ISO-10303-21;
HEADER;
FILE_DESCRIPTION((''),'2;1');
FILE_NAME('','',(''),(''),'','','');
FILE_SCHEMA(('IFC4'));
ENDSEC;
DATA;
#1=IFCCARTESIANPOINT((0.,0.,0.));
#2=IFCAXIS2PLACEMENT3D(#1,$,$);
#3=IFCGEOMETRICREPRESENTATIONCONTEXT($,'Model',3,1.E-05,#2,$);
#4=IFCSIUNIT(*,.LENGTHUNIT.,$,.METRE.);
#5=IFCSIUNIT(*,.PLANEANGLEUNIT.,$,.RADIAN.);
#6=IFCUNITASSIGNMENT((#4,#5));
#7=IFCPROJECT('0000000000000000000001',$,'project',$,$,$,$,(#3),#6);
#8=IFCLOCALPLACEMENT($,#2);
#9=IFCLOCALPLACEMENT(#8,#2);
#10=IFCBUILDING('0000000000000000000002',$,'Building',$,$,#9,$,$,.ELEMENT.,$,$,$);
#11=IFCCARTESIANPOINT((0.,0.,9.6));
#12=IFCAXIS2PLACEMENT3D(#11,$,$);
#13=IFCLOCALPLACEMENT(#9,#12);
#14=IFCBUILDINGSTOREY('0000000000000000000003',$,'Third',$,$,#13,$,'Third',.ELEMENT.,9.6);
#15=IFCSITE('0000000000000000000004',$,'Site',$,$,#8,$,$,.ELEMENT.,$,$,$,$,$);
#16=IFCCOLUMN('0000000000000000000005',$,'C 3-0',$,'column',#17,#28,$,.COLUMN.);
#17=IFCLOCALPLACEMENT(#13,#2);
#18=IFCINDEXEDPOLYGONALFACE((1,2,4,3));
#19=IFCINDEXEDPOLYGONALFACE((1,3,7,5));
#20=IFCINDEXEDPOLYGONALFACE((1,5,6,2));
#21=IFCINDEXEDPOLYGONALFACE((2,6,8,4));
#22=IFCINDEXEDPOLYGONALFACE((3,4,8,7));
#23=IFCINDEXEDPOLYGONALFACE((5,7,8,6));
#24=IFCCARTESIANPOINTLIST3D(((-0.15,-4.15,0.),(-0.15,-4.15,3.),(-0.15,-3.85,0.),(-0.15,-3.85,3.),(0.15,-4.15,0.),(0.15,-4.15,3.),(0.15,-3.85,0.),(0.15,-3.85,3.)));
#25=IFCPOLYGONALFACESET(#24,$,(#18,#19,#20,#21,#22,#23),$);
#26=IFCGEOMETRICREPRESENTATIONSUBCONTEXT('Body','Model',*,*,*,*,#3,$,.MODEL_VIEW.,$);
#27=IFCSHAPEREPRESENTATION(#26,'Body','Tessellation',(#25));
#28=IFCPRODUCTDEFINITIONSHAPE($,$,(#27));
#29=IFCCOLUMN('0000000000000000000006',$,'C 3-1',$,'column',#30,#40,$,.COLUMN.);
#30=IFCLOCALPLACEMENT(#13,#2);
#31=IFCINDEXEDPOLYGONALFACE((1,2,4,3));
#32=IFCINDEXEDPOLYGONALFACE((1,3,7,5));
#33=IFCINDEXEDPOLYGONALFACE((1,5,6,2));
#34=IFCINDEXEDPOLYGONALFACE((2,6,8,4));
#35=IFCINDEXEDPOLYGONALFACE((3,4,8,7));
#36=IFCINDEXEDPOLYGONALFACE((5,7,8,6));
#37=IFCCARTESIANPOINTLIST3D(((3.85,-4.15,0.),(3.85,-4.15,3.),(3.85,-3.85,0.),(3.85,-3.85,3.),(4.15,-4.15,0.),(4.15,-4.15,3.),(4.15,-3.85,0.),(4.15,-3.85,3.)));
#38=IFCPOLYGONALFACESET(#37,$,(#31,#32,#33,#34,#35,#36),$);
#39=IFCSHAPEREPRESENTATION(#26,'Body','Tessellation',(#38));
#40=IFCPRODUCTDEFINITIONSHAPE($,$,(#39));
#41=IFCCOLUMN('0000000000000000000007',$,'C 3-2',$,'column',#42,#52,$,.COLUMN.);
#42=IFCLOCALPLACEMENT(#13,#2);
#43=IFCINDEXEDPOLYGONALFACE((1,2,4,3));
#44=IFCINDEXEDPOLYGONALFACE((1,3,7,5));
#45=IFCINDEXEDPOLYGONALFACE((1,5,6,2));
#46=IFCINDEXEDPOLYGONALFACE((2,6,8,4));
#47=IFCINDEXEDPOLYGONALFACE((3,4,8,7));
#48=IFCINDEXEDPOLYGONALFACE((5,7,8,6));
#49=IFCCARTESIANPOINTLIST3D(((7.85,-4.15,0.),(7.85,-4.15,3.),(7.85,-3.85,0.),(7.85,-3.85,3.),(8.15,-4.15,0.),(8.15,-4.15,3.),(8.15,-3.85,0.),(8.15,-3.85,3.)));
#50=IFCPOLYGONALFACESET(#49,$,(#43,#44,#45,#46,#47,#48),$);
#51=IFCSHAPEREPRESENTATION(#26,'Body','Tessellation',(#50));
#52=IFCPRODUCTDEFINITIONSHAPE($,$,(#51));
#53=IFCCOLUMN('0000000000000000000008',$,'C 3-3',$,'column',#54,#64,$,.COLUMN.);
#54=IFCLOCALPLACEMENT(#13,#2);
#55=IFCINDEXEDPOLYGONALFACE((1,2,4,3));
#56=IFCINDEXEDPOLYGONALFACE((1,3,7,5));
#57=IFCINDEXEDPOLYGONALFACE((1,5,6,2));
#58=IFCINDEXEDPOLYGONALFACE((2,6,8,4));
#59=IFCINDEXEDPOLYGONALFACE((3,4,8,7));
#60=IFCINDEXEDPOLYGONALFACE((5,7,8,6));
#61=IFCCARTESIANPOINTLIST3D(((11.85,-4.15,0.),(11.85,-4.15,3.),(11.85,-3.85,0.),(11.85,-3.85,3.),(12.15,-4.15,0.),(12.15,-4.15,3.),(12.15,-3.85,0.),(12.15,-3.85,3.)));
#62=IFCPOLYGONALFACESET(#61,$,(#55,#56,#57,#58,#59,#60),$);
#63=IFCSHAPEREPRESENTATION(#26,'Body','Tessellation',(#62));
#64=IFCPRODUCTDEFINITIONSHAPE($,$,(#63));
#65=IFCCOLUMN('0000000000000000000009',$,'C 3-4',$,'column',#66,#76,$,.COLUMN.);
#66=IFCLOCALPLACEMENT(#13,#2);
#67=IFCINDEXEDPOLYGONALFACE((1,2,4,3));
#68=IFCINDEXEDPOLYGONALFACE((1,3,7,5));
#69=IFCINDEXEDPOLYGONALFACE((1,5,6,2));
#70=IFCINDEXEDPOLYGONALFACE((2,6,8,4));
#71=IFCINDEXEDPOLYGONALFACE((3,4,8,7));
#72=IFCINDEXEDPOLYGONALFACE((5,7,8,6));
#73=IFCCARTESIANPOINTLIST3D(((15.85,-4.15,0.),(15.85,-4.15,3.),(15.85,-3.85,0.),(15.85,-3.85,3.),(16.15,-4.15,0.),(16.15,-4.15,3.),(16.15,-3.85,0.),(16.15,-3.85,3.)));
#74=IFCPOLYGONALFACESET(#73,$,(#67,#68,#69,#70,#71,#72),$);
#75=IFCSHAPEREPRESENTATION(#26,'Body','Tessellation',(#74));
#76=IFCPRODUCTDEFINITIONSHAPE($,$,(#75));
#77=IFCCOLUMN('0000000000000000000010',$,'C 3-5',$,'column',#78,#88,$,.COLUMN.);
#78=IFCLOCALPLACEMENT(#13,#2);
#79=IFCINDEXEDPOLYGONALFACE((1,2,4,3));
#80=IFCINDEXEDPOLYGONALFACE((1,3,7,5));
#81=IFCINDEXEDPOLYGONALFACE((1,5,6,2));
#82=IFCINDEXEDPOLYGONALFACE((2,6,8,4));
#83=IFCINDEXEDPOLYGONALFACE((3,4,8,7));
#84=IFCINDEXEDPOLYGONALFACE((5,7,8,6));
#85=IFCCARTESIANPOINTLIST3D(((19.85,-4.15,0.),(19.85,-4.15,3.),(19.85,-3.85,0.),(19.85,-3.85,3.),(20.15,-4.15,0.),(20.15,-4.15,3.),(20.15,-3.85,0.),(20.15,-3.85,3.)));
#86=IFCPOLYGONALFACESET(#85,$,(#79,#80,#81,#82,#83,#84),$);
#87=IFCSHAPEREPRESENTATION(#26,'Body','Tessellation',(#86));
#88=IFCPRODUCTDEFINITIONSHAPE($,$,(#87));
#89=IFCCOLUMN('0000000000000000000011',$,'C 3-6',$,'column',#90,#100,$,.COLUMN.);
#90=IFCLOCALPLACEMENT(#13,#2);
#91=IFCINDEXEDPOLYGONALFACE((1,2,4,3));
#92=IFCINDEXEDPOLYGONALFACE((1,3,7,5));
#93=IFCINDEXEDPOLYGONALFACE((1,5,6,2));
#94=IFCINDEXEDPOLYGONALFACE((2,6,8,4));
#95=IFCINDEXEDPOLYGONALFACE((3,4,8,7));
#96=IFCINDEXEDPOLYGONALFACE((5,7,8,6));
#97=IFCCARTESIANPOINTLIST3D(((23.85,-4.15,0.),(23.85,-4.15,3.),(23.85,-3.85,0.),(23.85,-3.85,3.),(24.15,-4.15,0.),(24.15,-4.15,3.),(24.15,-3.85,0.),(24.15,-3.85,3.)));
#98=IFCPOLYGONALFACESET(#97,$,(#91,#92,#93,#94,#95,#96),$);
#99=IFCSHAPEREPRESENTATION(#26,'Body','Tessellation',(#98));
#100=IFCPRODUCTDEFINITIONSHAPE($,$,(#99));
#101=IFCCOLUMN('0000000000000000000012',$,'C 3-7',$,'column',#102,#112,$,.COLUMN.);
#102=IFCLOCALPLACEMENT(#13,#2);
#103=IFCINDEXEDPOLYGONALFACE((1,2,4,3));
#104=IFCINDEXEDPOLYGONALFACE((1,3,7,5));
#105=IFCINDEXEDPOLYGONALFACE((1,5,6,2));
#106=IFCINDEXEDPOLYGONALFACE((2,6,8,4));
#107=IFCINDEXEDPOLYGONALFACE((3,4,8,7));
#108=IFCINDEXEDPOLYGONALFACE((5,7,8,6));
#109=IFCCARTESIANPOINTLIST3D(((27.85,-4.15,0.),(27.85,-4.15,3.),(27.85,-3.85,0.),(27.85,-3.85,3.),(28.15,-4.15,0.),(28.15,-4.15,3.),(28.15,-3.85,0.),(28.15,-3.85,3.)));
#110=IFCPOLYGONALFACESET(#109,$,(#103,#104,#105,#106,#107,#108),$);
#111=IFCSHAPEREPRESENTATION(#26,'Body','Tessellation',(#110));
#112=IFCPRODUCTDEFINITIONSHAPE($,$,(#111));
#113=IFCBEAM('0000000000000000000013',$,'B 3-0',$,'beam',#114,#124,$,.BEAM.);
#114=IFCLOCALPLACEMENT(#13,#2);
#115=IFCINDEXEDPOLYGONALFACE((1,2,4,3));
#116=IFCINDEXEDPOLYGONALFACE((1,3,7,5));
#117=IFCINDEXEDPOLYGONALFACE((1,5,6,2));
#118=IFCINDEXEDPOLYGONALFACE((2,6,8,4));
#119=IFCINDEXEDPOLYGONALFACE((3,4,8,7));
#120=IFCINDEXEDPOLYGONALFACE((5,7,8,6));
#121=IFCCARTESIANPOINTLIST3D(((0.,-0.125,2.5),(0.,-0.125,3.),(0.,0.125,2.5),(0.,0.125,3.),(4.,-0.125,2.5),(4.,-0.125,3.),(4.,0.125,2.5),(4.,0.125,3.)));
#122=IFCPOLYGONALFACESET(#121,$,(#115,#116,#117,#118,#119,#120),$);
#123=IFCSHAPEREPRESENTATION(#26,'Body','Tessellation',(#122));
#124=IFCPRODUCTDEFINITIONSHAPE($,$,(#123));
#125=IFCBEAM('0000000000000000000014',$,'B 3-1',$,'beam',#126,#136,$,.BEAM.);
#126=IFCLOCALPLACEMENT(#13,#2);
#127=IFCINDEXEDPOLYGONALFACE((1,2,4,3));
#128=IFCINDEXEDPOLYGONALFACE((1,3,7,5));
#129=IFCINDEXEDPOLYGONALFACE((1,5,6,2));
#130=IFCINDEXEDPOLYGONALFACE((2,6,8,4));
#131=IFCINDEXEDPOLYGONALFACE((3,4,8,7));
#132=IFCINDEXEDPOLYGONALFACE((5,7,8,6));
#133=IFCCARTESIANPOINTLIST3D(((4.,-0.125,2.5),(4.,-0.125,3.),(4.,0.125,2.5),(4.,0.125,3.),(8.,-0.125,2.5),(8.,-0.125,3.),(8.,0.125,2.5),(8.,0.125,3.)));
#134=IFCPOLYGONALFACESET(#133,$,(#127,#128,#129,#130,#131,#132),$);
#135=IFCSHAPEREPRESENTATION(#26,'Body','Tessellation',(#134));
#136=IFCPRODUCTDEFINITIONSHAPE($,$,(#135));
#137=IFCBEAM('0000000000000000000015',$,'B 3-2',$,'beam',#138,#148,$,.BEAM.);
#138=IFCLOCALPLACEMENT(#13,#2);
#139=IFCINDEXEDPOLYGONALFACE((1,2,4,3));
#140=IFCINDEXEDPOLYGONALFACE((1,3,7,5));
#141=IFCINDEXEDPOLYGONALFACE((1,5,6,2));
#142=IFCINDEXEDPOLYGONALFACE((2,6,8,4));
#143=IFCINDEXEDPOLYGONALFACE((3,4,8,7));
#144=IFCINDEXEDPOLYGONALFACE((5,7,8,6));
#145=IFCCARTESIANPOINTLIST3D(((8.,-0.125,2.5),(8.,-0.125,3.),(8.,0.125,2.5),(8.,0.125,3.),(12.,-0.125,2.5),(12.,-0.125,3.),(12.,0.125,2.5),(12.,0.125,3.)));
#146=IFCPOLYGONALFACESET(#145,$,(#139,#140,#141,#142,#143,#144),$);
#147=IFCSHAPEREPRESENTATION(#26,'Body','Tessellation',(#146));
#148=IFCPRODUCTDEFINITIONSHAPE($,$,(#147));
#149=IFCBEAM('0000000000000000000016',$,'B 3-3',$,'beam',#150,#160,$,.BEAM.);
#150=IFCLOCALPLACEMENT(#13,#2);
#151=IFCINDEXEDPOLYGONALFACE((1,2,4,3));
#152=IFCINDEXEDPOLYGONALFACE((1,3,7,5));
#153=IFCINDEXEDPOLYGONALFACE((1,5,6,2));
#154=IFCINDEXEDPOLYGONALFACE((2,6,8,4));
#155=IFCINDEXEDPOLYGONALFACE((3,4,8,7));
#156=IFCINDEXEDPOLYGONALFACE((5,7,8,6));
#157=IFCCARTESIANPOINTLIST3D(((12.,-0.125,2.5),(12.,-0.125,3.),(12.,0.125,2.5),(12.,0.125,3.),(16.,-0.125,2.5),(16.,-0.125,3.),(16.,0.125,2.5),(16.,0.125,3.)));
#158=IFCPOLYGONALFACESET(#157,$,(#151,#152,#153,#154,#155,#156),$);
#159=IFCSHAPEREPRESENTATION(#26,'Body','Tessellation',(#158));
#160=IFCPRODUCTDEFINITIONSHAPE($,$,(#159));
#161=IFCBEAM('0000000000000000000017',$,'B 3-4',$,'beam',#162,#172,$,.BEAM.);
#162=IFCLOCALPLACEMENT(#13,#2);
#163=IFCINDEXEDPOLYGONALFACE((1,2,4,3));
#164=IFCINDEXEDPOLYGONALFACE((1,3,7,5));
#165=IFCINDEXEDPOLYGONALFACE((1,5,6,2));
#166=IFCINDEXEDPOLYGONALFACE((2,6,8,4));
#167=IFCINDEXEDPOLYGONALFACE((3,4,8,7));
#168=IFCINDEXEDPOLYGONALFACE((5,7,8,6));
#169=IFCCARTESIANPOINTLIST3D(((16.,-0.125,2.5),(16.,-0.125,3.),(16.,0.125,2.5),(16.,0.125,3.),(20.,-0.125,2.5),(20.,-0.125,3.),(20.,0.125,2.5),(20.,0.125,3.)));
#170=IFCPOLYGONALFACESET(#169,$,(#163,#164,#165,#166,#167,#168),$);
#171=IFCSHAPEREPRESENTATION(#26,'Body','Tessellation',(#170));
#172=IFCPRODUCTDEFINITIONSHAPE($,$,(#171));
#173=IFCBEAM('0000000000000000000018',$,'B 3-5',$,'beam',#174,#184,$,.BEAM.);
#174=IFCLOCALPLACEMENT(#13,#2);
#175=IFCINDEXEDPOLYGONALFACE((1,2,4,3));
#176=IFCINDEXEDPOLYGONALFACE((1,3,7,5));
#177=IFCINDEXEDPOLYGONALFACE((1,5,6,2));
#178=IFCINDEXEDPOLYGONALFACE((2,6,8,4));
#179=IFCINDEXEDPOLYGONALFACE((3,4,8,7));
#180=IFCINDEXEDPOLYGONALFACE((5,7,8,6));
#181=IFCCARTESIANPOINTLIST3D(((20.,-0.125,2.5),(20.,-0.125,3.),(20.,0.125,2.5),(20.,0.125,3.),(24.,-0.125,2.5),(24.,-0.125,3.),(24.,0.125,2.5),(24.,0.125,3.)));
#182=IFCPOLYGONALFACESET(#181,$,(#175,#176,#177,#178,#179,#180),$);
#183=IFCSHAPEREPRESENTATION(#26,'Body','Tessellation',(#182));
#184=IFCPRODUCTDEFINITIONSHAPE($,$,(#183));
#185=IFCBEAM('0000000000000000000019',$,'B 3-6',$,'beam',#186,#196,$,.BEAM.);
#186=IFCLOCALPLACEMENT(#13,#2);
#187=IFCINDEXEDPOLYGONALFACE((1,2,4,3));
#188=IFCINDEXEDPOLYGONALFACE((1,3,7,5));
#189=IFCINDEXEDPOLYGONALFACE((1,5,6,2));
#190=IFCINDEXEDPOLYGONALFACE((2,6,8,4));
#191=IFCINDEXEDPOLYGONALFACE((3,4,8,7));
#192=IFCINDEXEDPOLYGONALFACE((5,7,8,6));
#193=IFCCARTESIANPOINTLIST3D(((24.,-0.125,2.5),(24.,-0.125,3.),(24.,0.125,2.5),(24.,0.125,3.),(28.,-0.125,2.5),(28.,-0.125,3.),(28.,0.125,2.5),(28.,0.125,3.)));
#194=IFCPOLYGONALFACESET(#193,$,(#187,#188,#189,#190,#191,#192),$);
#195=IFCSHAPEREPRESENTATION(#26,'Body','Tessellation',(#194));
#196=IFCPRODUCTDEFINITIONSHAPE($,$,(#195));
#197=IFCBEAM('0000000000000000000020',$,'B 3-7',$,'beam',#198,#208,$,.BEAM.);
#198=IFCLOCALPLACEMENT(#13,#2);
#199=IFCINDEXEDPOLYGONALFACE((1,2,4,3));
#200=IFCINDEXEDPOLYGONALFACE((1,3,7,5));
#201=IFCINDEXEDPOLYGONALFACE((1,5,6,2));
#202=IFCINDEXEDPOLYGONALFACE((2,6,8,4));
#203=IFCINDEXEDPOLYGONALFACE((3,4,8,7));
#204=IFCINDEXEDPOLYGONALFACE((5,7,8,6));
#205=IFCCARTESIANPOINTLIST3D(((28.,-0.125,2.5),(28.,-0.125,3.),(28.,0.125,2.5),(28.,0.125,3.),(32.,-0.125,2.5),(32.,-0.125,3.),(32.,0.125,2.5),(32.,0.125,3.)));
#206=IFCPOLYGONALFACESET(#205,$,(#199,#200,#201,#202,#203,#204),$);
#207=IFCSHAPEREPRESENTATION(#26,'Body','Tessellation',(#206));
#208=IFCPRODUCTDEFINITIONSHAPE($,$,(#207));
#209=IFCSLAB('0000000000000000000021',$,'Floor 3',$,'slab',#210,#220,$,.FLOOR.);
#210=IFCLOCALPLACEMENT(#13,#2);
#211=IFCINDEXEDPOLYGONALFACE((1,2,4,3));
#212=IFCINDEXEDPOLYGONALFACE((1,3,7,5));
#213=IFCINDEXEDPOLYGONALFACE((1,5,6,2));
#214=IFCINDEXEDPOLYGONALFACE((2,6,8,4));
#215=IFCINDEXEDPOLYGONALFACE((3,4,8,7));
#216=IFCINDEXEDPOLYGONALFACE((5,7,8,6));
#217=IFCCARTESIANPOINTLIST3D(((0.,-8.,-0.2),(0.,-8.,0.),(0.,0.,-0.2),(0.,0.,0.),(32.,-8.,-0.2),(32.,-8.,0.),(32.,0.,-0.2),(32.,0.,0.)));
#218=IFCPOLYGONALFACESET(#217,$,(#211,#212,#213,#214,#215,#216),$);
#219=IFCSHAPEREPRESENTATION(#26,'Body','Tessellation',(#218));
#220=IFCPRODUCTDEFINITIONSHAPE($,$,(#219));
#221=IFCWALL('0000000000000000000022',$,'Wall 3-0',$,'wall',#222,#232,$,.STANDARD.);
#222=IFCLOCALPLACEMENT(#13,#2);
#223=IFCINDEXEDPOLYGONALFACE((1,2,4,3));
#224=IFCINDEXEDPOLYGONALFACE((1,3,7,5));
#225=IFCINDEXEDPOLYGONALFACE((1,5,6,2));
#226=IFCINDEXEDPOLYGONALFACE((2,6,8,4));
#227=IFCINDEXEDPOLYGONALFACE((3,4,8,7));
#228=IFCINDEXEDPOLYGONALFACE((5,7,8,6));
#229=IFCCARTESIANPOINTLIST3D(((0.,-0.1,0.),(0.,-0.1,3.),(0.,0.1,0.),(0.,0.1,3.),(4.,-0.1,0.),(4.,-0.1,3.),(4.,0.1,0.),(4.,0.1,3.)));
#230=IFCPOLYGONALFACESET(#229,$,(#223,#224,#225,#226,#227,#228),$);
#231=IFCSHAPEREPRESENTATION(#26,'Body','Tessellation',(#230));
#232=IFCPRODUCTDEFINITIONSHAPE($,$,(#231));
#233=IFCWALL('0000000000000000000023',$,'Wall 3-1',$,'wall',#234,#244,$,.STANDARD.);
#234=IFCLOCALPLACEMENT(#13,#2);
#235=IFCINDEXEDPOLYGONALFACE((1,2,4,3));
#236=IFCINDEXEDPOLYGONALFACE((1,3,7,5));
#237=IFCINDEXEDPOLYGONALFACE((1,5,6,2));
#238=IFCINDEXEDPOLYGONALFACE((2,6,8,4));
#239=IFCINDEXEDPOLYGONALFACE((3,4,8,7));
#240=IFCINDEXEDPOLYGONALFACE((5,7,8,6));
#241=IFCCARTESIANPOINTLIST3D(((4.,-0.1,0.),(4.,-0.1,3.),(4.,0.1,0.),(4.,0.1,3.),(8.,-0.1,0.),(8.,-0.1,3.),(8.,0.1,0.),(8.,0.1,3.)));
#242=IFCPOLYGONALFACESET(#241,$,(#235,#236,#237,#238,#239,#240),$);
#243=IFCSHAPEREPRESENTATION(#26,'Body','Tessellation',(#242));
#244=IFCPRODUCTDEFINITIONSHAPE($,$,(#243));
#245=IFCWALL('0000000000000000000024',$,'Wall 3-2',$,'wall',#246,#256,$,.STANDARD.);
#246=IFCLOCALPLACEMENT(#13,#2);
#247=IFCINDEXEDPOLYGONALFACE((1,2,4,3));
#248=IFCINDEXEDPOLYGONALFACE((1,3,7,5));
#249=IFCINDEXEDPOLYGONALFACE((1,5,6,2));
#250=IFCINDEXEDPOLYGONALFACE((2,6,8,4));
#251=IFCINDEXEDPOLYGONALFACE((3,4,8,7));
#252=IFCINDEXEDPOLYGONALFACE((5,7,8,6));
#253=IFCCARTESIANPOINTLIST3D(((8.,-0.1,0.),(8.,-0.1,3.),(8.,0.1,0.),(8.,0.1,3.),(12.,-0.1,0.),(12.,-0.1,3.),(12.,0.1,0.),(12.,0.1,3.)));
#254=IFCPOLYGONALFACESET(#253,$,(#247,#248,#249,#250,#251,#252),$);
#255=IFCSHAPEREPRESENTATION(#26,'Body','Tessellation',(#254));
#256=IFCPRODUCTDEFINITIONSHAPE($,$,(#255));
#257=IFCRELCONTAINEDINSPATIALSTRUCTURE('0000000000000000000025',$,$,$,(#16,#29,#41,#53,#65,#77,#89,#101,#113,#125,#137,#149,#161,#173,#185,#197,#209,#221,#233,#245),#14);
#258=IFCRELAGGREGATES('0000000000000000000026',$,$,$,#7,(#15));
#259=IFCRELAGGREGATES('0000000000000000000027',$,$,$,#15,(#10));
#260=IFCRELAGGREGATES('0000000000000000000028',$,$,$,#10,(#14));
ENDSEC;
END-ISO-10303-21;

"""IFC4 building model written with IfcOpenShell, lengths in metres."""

from ifc_helpers import new_model, si_unit, frame, frame_2d, origin, origin_2d, place, context, subcontext, project, spatial, polyline, rectangle, outline, extrude, element, save


model = new_model("IFC4")

# Units and contexts
model_context = context("Model", 3, precision=1e-05, world=origin())
body_context = subcontext(model_context, "Body", "Model", "MODEL_VIEW")
ifc_project = project(units=[si_unit("LENGTHUNIT", "METRE"), si_unit("PLANEANGLEUNIT", "RADIAN")], contexts=[model_context])

# Site, building, storey
site_placement = place(None, origin())
site = spatial("IfcSite", under=ifc_project, at=site_placement, Name="Site", CompositionType="ELEMENT")
building_placement = place(site_placement, origin())
building = spatial("IfcBuilding", under=site, at=building_placement, Name="Building", CompositionType="ELEMENT")
storey_placement = place(building_placement, frame((0.0, 0.0, 9.6)))
storey = spatial("IfcBuildingStorey", under=building, at=storey_placement, Name="Third", LongName="Third", CompositionType="ELEMENT", Elevation=9.6)

# Columns
for number, where, name in (
    (1, (0.0, -4.0, 0.0), "C 3-0"),
    (2, (4.0, -4.0, 0.0), "C 3-1"),
    (3, (8.0, -4.0, 0.0), "C 3-2"),
    (4, (12.0, -4.0, 0.0), "C 3-3"),
    (5, (16.0, -4.0, 0.0), "C 3-4"),
    (6, (20.0, -4.0, 0.0), "C 3-5"),
    (7, (24.0, -4.0, 0.0), "C 3-6"),
    (8, (28.0, -4.0, 0.0), "C 3-7"),
):
    element("IfcColumn", number, at=place(storey_placement, frame(where)), inside=storey, Name=name, ObjectType="column", PredefinedType="COLUMN", context=body_context, shape_type="SweptSolid", body=[
        extrude(rectangle(XDim=0.3, YDim=0.3, at=origin_2d()), origin(), (0.0, 0.0, 1.0), 3.0),
    ])

# Beams
for number, where, z_axis, x_axis, name in (
    (9, (0.0, 0.0, 2.75), (1.0, 0.0, 0.0), (0.0, 0.0, 1.0), "B 3-0"),
    (10, (4.0, 0.0, 2.75), (1.0, 0.0, 0.0), (0.0, 0.0, 1.0), "B 3-1"),
    (11, (8.0, 0.0, 2.75), (1.0, 0.0, 0.0), (0.0, 0.0, 1.0), "B 3-2"),
    (12, (12.0, 0.0, 2.75), (1.0, 0.0, 0.0), (0.0, 0.0, 1.0), "B 3-3"),
    (13, (16.0, 0.0, 2.75), (1.0, 0.0, 0.0), (0.0, 0.0, 1.0), "B 3-4"),
    (14, (20.0, 0.0, 2.75), (1.0, 0.0, 0.0), (0.0, 0.0, 1.0), "B 3-5"),
    (15, (24.0, 0.0, 2.75), (1.0, 0.0, 0.0), (0.0, 0.0, 1.0), "B 3-6"),
    (16, (28.0, 0.0, 2.75), (1.0, 0.0, 0.0), (0.0, 0.0, 1.0), "B 3-7"),
):
    element("IfcBeam", number, at=place(storey_placement, frame(where, z_axis=z_axis, x_axis=x_axis)), inside=storey, Name=name, ObjectType="beam", PredefinedType="BEAM", context=body_context, shape_type="SweptSolid", body=[
        extrude(rectangle(XDim=0.5, YDim=0.25, at=origin_2d()), origin(), (0.0, 0.0, 1.0), 4.0),
    ])

# Slab
slab_placement = place(storey_placement, frame((0.0, 0.0, -0.2)))
element("IfcSlab", 17, at=slab_placement, inside=storey, Name="Floor 3", ObjectType="slab", PredefinedType="FLOOR", context=body_context, shape_type="SweptSolid", body=[
    extrude(outline(polyline([(0.0, -8.0), (32.0, -8.0), (32.0, 0.0), (0.0, 0.0), (0.0, -8.0)])), origin(), (0.0, 0.0, 1.0), 0.2),
])

# Walls
for number, where, z_axis, x_axis, name in (
    (18, (0.0, 0.0, 0.0), (0.0, 0.0, 1.0), (1.0, 0.0, 0.0), "Wall 3-0"),
    (19, (4.0, 0.0, 0.0), (0.0, 0.0, 1.0), (1.0, 0.0, 0.0), "Wall 3-1"),
    (20, (8.0, 0.0, 0.0), (0.0, 0.0, 1.0), (1.0, 0.0, 0.0), "Wall 3-2"),
):
    element("IfcWall", number, at=place(storey_placement, frame(where, z_axis=z_axis, x_axis=x_axis)), inside=storey, Name=name, ObjectType="wall", PredefinedType="STANDARD", context=body_context, shape_type="SweptSolid", body=[
        extrude(rectangle(XDim=4.0, YDim=0.2, at=frame_2d((2.0, 0.0))), origin(), (0.0, 0.0, 1.0), 3.0),
    ])

save(model, "model.ifc")
